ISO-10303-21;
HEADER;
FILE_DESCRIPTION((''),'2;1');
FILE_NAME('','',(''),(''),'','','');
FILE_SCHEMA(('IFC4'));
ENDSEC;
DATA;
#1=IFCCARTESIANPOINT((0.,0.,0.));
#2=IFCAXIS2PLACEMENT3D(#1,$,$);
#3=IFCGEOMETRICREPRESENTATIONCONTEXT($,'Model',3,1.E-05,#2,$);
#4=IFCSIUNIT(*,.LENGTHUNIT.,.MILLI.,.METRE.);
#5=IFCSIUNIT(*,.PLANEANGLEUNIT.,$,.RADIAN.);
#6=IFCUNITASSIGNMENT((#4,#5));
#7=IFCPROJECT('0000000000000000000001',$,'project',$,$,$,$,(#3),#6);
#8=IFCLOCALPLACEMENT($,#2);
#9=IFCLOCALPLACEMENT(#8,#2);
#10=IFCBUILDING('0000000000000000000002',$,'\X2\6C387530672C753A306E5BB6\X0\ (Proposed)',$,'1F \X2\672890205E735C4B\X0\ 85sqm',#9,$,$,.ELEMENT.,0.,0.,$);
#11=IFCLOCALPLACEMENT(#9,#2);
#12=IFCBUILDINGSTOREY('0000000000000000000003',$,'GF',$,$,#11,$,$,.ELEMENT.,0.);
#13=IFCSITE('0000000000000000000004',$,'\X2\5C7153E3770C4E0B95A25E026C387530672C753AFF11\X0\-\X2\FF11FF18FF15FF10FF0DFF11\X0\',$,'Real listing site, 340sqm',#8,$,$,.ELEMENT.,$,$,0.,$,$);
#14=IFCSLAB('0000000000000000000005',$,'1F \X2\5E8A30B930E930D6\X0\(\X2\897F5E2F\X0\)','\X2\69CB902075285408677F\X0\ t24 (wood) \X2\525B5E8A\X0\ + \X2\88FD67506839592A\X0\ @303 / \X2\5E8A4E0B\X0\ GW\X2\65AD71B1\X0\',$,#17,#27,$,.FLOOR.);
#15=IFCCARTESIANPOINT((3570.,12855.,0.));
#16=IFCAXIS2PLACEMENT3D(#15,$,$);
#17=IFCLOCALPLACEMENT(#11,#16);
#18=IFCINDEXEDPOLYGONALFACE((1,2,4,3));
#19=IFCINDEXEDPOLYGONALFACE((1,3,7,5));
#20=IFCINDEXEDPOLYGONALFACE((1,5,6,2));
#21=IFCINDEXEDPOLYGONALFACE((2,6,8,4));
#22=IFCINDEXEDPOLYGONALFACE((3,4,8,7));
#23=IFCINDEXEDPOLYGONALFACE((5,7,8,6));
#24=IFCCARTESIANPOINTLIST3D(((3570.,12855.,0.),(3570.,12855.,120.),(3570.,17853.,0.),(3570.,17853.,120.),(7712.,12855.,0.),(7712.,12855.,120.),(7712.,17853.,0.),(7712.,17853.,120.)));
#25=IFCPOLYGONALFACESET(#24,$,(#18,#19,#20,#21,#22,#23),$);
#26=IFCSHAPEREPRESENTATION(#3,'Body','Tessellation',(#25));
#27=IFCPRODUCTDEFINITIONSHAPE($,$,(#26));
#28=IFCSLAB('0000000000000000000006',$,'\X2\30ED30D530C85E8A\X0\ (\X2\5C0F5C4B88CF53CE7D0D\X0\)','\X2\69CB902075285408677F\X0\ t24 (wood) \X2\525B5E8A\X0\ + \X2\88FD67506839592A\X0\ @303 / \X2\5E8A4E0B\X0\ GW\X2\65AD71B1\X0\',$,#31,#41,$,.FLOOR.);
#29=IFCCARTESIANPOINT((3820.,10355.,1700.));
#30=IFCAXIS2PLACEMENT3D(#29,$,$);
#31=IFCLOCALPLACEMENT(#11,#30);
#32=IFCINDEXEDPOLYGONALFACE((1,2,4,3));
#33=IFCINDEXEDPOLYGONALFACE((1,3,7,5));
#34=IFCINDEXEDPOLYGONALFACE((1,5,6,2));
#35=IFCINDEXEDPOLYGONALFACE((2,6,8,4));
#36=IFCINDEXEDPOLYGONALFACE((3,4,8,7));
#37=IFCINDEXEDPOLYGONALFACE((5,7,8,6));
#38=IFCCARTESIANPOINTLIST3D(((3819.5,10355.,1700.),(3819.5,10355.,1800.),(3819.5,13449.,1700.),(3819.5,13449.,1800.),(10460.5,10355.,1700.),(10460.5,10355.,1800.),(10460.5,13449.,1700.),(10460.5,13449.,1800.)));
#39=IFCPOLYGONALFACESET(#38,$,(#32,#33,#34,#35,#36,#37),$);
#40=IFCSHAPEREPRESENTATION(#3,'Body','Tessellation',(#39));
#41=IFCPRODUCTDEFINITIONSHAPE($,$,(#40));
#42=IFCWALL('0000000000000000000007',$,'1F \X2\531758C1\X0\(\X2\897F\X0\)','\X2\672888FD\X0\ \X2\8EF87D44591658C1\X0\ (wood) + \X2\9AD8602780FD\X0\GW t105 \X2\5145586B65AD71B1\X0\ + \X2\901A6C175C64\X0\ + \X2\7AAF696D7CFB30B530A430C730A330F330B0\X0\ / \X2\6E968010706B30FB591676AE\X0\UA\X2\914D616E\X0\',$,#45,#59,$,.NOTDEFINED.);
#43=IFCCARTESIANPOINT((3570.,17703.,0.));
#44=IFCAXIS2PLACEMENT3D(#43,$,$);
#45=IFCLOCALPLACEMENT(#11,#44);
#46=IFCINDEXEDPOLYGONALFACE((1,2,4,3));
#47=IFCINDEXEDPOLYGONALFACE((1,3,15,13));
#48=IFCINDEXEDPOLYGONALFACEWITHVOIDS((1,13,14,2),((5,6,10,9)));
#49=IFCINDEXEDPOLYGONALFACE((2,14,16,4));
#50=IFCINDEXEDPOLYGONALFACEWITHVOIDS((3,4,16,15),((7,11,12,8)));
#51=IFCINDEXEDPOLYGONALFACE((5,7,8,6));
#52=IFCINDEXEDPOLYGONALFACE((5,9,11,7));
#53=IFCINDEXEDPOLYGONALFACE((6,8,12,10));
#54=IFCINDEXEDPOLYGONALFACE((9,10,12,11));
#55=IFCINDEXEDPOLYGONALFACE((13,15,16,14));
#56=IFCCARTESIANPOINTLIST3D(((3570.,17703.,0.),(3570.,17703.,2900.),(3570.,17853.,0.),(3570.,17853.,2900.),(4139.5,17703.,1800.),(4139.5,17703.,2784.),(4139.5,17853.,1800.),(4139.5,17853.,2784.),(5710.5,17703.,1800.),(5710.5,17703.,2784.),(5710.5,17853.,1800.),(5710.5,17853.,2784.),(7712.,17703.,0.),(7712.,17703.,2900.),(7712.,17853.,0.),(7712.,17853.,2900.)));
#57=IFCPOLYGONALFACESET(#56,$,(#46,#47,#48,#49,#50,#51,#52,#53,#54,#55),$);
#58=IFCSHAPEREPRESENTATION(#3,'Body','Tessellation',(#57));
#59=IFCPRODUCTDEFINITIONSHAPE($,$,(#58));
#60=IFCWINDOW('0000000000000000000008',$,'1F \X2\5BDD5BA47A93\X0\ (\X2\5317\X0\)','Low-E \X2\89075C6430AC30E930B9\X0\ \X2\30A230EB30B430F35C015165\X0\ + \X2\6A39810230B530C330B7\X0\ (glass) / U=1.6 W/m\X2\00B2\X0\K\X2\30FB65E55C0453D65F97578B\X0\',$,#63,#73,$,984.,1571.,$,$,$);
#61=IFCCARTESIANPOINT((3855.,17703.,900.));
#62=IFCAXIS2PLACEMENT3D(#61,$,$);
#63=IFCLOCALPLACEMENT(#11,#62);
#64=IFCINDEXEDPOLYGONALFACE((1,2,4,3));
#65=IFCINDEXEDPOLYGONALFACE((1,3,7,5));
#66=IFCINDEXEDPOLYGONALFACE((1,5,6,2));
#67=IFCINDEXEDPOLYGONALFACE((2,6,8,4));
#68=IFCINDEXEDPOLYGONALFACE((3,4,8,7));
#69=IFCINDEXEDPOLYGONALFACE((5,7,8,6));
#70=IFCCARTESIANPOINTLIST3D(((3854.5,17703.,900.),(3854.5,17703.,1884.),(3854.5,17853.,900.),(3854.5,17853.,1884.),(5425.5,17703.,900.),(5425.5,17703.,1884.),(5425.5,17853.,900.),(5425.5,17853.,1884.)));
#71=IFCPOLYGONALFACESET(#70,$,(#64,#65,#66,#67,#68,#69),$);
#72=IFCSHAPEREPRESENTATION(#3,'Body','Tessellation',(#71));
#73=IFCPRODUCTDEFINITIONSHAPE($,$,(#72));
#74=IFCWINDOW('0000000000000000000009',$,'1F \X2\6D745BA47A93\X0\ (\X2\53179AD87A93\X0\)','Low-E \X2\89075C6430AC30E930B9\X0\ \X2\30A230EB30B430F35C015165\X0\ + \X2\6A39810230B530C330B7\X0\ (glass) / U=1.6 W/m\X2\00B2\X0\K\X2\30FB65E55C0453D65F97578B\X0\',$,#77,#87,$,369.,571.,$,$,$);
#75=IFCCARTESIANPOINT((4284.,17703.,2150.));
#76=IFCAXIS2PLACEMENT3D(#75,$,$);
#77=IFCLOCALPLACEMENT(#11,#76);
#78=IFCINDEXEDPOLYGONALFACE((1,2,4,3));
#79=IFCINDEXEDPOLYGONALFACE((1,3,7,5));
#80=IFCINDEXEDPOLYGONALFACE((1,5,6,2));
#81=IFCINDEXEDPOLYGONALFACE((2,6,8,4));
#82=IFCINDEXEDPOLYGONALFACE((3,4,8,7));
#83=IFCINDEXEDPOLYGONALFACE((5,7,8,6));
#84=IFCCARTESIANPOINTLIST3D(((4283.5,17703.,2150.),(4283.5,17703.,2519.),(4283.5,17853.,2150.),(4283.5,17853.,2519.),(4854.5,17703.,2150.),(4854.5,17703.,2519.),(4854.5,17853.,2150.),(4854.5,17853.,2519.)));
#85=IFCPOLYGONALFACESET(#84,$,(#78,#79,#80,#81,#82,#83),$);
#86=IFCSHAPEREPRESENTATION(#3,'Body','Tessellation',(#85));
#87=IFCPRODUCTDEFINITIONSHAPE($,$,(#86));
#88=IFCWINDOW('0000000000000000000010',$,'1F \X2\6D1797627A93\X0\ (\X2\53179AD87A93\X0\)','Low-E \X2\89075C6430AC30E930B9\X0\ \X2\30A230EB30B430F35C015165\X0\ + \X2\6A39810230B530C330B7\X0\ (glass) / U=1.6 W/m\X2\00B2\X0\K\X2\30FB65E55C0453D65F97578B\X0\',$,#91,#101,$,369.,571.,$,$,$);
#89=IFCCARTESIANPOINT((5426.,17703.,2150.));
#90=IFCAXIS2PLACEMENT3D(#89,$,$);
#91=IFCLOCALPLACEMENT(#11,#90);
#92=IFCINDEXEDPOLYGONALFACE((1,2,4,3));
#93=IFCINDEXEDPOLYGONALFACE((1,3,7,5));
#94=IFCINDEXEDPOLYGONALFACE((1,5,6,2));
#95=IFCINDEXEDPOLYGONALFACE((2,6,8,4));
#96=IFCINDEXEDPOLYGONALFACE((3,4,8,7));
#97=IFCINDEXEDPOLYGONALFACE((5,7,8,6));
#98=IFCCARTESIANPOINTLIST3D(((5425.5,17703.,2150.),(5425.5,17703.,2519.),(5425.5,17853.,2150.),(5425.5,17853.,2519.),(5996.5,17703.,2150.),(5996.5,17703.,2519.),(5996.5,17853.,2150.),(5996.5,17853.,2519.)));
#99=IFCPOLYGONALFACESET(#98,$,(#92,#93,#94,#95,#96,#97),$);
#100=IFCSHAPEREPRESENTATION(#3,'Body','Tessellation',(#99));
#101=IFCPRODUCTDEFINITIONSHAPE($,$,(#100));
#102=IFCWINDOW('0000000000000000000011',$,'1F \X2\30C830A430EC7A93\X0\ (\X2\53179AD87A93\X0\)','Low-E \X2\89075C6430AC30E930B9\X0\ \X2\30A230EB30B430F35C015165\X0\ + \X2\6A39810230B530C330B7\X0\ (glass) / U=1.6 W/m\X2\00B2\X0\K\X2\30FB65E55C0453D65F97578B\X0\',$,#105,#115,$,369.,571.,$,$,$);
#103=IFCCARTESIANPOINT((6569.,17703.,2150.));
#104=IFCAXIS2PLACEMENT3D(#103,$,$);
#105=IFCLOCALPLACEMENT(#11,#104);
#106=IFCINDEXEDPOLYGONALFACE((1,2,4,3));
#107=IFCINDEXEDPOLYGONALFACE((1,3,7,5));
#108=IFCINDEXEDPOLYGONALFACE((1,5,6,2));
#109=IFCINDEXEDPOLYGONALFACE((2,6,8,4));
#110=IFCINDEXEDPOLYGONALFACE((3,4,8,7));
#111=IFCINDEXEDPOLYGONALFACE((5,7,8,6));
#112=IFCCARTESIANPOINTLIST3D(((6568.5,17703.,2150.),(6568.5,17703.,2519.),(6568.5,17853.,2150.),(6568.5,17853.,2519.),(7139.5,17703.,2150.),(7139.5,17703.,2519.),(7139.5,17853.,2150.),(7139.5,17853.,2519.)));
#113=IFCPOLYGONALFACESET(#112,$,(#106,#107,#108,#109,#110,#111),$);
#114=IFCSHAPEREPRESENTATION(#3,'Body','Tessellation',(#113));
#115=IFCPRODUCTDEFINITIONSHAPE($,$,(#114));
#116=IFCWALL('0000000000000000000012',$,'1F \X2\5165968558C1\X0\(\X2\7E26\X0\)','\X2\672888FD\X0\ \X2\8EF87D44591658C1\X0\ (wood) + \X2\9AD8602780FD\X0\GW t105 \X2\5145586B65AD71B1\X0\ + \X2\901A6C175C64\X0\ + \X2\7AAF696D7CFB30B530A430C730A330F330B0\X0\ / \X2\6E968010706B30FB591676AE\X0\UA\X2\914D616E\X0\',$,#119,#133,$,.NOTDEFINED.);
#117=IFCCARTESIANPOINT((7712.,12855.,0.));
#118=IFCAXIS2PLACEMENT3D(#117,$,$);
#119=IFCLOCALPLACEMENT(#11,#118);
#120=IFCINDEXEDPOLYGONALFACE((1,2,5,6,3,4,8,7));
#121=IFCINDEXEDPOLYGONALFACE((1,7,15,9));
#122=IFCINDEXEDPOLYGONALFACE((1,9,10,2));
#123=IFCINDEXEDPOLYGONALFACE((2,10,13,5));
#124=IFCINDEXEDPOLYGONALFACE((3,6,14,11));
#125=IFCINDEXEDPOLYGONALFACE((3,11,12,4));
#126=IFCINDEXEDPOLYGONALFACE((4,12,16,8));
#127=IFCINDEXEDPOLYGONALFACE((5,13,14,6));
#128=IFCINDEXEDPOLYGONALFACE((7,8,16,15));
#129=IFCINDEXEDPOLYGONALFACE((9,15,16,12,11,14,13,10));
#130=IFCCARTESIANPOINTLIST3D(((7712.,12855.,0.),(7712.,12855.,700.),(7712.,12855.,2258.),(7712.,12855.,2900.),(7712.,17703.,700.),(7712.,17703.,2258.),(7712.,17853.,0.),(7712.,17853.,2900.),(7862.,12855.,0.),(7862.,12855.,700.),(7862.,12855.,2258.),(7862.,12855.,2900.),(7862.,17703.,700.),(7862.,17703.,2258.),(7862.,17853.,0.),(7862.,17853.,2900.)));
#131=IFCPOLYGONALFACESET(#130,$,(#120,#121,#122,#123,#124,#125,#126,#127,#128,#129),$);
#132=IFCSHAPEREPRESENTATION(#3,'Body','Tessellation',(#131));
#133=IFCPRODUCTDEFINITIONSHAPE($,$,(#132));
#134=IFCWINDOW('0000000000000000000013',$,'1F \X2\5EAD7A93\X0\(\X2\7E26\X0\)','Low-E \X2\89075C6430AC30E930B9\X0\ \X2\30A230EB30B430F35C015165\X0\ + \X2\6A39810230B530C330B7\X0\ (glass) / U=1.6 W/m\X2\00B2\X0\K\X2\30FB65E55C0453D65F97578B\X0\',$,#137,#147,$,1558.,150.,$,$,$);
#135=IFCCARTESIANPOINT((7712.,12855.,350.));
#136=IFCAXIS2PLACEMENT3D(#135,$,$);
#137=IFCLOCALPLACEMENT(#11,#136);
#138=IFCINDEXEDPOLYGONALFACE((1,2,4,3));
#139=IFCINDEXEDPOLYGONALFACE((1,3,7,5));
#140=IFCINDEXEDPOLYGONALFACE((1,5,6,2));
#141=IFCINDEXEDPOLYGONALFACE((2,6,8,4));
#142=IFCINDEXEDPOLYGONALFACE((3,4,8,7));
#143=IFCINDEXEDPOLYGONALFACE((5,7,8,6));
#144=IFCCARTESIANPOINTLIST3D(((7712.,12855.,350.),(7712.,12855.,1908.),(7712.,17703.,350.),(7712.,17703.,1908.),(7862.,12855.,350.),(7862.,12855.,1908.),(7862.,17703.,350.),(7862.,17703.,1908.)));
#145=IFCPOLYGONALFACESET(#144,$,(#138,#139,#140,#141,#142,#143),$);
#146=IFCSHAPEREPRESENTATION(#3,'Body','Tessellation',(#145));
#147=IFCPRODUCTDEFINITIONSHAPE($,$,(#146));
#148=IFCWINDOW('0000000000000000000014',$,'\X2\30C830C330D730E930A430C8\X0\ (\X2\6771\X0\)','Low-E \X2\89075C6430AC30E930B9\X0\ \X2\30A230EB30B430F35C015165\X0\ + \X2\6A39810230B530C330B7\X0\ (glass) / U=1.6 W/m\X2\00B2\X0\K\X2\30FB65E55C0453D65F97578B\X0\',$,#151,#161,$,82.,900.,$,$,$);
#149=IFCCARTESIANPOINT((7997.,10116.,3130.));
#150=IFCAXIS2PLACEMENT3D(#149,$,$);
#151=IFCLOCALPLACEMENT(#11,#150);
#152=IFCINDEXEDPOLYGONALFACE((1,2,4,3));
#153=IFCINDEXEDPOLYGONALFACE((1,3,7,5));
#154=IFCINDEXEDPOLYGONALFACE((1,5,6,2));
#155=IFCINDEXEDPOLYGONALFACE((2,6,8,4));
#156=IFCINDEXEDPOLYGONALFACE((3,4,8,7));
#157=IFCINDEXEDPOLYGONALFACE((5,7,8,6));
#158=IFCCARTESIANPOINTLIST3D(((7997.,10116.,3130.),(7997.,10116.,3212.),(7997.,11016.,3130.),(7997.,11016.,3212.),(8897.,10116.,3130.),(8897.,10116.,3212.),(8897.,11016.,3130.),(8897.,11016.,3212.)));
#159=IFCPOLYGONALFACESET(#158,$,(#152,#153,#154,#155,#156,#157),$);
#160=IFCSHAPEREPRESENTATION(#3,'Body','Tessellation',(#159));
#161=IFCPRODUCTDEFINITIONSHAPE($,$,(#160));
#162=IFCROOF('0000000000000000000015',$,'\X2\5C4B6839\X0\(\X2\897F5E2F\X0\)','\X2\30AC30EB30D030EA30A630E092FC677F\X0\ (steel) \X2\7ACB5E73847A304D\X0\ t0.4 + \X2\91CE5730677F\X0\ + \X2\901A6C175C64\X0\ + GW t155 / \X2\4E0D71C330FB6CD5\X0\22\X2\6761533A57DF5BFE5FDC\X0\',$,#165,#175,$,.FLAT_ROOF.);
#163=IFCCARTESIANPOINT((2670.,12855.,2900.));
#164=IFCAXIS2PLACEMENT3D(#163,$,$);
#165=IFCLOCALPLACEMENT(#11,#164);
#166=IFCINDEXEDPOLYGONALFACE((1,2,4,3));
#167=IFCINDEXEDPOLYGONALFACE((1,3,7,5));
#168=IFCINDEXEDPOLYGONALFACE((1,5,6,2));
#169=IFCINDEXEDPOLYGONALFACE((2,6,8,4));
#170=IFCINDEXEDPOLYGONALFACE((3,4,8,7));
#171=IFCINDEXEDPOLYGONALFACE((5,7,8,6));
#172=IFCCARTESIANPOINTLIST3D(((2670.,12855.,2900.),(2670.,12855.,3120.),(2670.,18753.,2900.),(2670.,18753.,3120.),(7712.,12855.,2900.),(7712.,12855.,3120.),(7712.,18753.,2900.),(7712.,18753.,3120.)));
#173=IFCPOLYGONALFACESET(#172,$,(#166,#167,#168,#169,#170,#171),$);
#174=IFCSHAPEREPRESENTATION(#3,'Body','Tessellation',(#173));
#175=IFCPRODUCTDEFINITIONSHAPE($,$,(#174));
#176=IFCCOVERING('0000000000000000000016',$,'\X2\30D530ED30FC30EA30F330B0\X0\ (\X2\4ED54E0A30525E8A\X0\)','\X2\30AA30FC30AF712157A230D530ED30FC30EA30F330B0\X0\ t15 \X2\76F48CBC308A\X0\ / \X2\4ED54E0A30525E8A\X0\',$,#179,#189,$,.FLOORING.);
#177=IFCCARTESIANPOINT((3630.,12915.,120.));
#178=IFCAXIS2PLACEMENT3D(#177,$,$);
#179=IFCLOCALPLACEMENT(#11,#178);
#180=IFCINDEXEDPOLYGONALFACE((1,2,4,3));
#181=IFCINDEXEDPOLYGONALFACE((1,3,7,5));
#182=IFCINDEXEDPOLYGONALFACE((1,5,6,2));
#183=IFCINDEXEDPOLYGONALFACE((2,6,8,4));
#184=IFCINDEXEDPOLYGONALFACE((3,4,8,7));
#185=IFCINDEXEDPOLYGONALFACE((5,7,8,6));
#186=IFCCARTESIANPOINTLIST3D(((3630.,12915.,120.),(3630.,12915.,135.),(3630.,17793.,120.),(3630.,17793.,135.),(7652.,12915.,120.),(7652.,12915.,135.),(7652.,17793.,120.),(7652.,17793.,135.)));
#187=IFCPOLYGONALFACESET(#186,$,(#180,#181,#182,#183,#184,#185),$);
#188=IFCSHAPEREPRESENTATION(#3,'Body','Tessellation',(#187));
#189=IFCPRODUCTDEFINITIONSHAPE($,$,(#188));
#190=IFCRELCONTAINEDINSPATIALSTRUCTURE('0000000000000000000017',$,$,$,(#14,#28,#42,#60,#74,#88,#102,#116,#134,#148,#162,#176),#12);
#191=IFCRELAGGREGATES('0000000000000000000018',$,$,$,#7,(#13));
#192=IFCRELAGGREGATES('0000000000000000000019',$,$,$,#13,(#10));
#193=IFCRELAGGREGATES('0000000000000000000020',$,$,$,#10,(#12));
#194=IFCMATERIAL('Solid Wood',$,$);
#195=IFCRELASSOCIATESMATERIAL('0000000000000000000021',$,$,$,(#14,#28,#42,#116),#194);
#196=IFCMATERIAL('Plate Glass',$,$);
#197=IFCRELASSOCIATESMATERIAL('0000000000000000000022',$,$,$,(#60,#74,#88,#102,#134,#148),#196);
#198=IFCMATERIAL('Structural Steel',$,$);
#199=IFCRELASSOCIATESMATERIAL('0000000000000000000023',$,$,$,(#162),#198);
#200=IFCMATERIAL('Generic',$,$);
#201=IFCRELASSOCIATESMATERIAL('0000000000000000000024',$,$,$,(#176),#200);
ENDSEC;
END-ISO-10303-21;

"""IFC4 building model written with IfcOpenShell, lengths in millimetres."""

from ifc_helpers import new_model, si_unit, frame, frame_2d, origin, place, context, project, spatial, rectangle, extrude, material, element, fill, save


model = new_model("IFC4")

# Units and contexts
model_context = context("Model", 3, precision=1e-05, world=origin())
ifc_project = project(units=[si_unit("LENGTHUNIT", "METRE", prefix="MILLI"), si_unit("PLANEANGLEUNIT", "RADIAN")], contexts=[model_context])

# Site, building, storey
site_placement = place(None, origin())
site = spatial("IfcSite", under=ifc_project, at=site_placement, Name="山口県下関市永田本町１-１８５０－１", ObjectType="Real listing site, 340sqm", CompositionType="ELEMENT", RefElevation=0.0)
building_placement = place(site_placement, origin())
building = spatial("IfcBuilding", under=site, at=building_placement, Name="永田本町の家 (Proposed)", ObjectType="1F 木造平屋 85sqm", CompositionType="ELEMENT", ElevationOfRefHeight=0.0, ElevationOfTerrain=0.0)
storey_placement = place(building_placement, origin())
storey = spatial("IfcBuildingStorey", under=building, at=storey_placement, Name="GF", CompositionType="ELEMENT", Elevation=0.0)

# Slabs
ifc_material_1 = material(Name="Solid Wood")
slab_1_placement = place(storey_placement, frame((3570.0, 12855.0, 0.0)))
element("IfcSlab", 1, at=slab_1_placement, inside=storey, material=ifc_material_1, Name="1F 床スラブ(西帯)", Description="構造用合板 t24 (wood) 剛床 + 製材根太 @303 / 床下 GW断熱", PredefinedType="FLOOR", context=model_context, shape_type="SweptSolid", body=[
    extrude(rectangle(XDim=4142.0, YDim=4998.0, at=frame_2d((2071.0, 2499.0))), frame((3570.0, 12855.0, 0.0)), (0.0, 0.0, 1.0), 120.0),
])
slab_2_placement = place(storey_placement, frame((3820.0, 10355.0, 1700.0)))
element("IfcSlab", 2, at=slab_2_placement, inside=storey, material=ifc_material_1, Name="ロフト床 (小屋裏収納)", Description="構造用合板 t24 (wood) 剛床 + 製材根太 @303 / 床下 GW断熱", PredefinedType="FLOOR", context=model_context, shape_type="SweptSolid", body=[
    extrude(rectangle(XDim=6641.0, YDim=3094.0, at=frame_2d((3320.0, 1547.0))), frame((3820.0, 10355.0, 1700.0)), (0.0, 0.0, 1.0), 100.0),
])

# Wall, openings, windows
wall_1_placement = place(storey_placement, frame((3570.0, 17703.0, 0.0)))
wall_1 = element("IfcWall", 3, at=wall_1_placement, inside=storey, material=ifc_material_1, Name="1F 北壁(西)", Description="木製 軸組外壁 (wood) + 高性能GW t105 充填断熱 + 通気層 + 窯業系サイディング / 準耐火・外皮UA配慮", PredefinedType="NOTDEFINED", context=model_context, shape_type="SweptSolid", body=[
    extrude(rectangle(XDim=4142.0, YDim=150.0, at=frame_2d((2071.0, 75.0))), frame((3570.0, 17703.0, 0.0)), (0.0, 0.0, 1.0), 2900.0),
])
opening_1_placement = place(storey_placement, frame((3855.0, 17703.0, 900.0)))
opening_1 = element("IfcOpeningElement", 4, at=opening_1_placement, cuts=wall_1, PredefinedType="NOTDEFINED", context=model_context, shape_type="SweptSolid", body=[
    extrude(rectangle(XDim=1571.0, YDim=150.0, at=frame_2d((785.0, 75.0))), frame((3855.0, 17703.0, 900.0)), (0.0, 0.0, 1.0), 984.0),
])
opening_2_placement = place(storey_placement, frame((4284.0, 17703.0, 2150.0)))
opening_2 = element("IfcOpeningElement", 5, at=opening_2_placement, cuts=wall_1, PredefinedType="NOTDEFINED", context=model_context, shape_type="SweptSolid", body=[
    extrude(rectangle(XDim=571.0, YDim=150.0, at=frame_2d((285.0, 75.0))), frame((4284.0, 17703.0, 2150.0)), (0.0, 0.0, 1.0), 369.0),
])
opening_3_placement = place(storey_placement, frame((5426.0, 17703.0, 2150.0)))
opening_3 = element("IfcOpeningElement", 6, at=opening_3_placement, cuts=wall_1, PredefinedType="NOTDEFINED", context=model_context, shape_type="SweptSolid", body=[
    extrude(rectangle(XDim=571.0, YDim=150.0, at=frame_2d((285.0, 75.0))), frame((5426.0, 17703.0, 2150.0)), (0.0, 0.0, 1.0), 369.0),
])
opening_4_placement = place(storey_placement, frame((6569.0, 17703.0, 2150.0)))
opening_4 = element("IfcOpeningElement", 7, at=opening_4_placement, cuts=wall_1, PredefinedType="NOTDEFINED", context=model_context, shape_type="SweptSolid", body=[
    extrude(rectangle(XDim=571.0, YDim=150.0, at=frame_2d((285.0, 75.0))), frame((6569.0, 17703.0, 2150.0)), (0.0, 0.0, 1.0), 369.0),
])
ifc_material_2 = material(Name="Plate Glass")
window_1_placement = place(storey_placement, frame((3855.0, 17703.0, 900.0)))
window_1 = element("IfcWindow", 8, at=window_1_placement, inside=storey, material=ifc_material_2, Name="1F 寝室窓 (北)", Description="Low-E 複層ガラス アルゴン封入 + 樹脂サッシ (glass) / U=1.6 W/m²K・日射取得型", OverallHeight=984.0, OverallWidth=1571.0, context=model_context, shape_type="SweptSolid", body=[
    extrude(rectangle(XDim=1571.0, YDim=150.0, at=frame_2d((785.0, 75.0))), frame((3855.0, 17703.0, 900.0)), (0.0, 0.0, 1.0), 984.0),
])
fill(opening_1, window_1)
window_2_placement = place(storey_placement, frame((4284.0, 17703.0, 2150.0)))
window_2 = element("IfcWindow", 9, at=window_2_placement, inside=storey, material=ifc_material_2, Name="1F 浴室窓 (北高窓)", Description="Low-E 複層ガラス アルゴン封入 + 樹脂サッシ (glass) / U=1.6 W/m²K・日射取得型", OverallHeight=369.0, OverallWidth=571.0, context=model_context, shape_type="SweptSolid", body=[
    extrude(rectangle(XDim=571.0, YDim=150.0, at=frame_2d((285.0, 75.0))), frame((4284.0, 17703.0, 2150.0)), (0.0, 0.0, 1.0), 369.0),
])
fill(opening_2, window_2)
window_3_placement = place(storey_placement, frame((5426.0, 17703.0, 2150.0)))
window_3 = element("IfcWindow", 10, at=window_3_placement, inside=storey, material=ifc_material_2, Name="1F 洗面窓 (北高窓)", Description="Low-E 複層ガラス アルゴン封入 + 樹脂サッシ (glass) / U=1.6 W/m²K・日射取得型", OverallHeight=369.0, OverallWidth=571.0, context=model_context, shape_type="SweptSolid", body=[
    extrude(rectangle(XDim=571.0, YDim=150.0, at=frame_2d((285.0, 75.0))), frame((5426.0, 17703.0, 2150.0)), (0.0, 0.0, 1.0), 369.0),
])
fill(opening_3, window_3)
window_4_placement = place(storey_placement, frame((6569.0, 17703.0, 2150.0)))
window_4 = element("IfcWindow", 11, at=window_4_placement, inside=storey, material=ifc_material_2, Name="1F トイレ窓 (北高窓)", Description="Low-E 複層ガラス アルゴン封入 + 樹脂サッシ (glass) / U=1.6 W/m²K・日射取得型", OverallHeight=369.0, OverallWidth=571.0, context=model_context, shape_type="SweptSolid", body=[
    extrude(rectangle(XDim=571.0, YDim=150.0, at=frame_2d((285.0, 75.0))), frame((6569.0, 17703.0, 2150.0)), (0.0, 0.0, 1.0), 369.0),
])
fill(opening_4, window_4)

# Wall, opening, window
wall_2_placement = place(storey_placement, frame((7712.0, 12855.0, 0.0)))
wall_2 = element("IfcWall", 12, at=wall_2_placement, inside=storey, material=ifc_material_1, Name="1F 入隅壁(縦)", Description="木製 軸組外壁 (wood) + 高性能GW t105 充填断熱 + 通気層 + 窯業系サイディング / 準耐火・外皮UA配慮", PredefinedType="NOTDEFINED", context=model_context, shape_type="SweptSolid", body=[
    extrude(rectangle(XDim=150.0, YDim=4998.0, at=frame_2d((75.0, 2499.0))), frame((7712.0, 12855.0, 0.0)), (0.0, 0.0, 1.0), 2900.0),
])
opening_5_placement = place(storey_placement, frame((7712.0, 12855.0, 350.0)))
opening_5 = element("IfcOpeningElement", 13, at=opening_5_placement, cuts=wall_2, PredefinedType="NOTDEFINED", context=model_context, shape_type="SweptSolid", body=[
    extrude(rectangle(XDim=150.0, YDim=4848.0, at=frame_2d((75.0, 2424.0))), frame((7712.0, 12855.0, 350.0)), (0.0, 0.0, 1.0), 1558.0),
])
window_5_placement = place(storey_placement, frame((7712.0, 12855.0, 350.0)))
window_5 = element("IfcWindow", 14, at=window_5_placement, inside=storey, material=ifc_material_2, Name="1F 庭窓(縦)", Description="Low-E 複層ガラス アルゴン封入 + 樹脂サッシ (glass) / U=1.6 W/m²K・日射取得型", OverallHeight=1558.0, OverallWidth=150.0, context=model_context, shape_type="SweptSolid", body=[
    extrude(rectangle(XDim=150.0, YDim=4848.0, at=frame_2d((75.0, 2424.0))), frame((7712.0, 12855.0, 350.0)), (0.0, 0.0, 1.0), 1558.0),
])
fill(opening_5, window_5)

# Window
window_6_placement = place(storey_placement, frame((7997.0, 10116.0, 3130.0)))
element("IfcWindow", 15, at=window_6_placement, inside=storey, material=ifc_material_2, Name="トップライト (東)", Description="Low-E 複層ガラス アルゴン封入 + 樹脂サッシ (glass) / U=1.6 W/m²K・日射取得型", OverallHeight=82.0, OverallWidth=900.0, context=model_context, shape_type="SweptSolid", body=[
    extrude(rectangle(XDim=900.0, YDim=900.0, at=frame_2d((450.0, 450.0))), frame((7997.0, 10116.0, 3130.0)), (0.0, 0.0, 1.0), 82.0),
])

# Roof
ifc_material_3 = material(Name="Structural Steel")
roof_placement = place(storey_placement, frame((2670.0, 12855.0, 2900.0)))
element("IfcRoof", 16, at=roof_placement, inside=storey, material=ifc_material_3, Name="屋根(西帯)", Description="ガルバリウム鋼板 (steel) 立平葺き t0.4 + 野地板 + 通気層 + GW t155 / 不燃・法22条区域対応", PredefinedType="FLAT_ROOF", context=model_context, shape_type="SweptSolid", body=[
    extrude(rectangle(XDim=5042.0, YDim=5898.0, at=frame_2d((2521.0, 2949.0))), frame((2670.0, 12855.0, 2900.0)), (0.0, 0.0, 1.0), 220.0),
])

# Covering
ifc_material_4 = material(Name="Generic")
covering_placement = place(storey_placement, frame((3630.0, 12915.0, 120.0)))
element("IfcCovering", 17, at=covering_placement, inside=storey, material=ifc_material_4, Name="フローリング (仕上げ床)", Description="オーク無垢フローリング t15 直貼り / 仕上げ床", PredefinedType="FLOORING", context=model_context, shape_type="SweptSolid", body=[
    extrude(rectangle(XDim=4022.0, YDim=4878.0, at=frame_2d((2011.0, 2439.0))), frame((3630.0, 12915.0, 120.0)), (0.0, 0.0, 1.0), 15.0),
])

save(model, "model.ifc")
